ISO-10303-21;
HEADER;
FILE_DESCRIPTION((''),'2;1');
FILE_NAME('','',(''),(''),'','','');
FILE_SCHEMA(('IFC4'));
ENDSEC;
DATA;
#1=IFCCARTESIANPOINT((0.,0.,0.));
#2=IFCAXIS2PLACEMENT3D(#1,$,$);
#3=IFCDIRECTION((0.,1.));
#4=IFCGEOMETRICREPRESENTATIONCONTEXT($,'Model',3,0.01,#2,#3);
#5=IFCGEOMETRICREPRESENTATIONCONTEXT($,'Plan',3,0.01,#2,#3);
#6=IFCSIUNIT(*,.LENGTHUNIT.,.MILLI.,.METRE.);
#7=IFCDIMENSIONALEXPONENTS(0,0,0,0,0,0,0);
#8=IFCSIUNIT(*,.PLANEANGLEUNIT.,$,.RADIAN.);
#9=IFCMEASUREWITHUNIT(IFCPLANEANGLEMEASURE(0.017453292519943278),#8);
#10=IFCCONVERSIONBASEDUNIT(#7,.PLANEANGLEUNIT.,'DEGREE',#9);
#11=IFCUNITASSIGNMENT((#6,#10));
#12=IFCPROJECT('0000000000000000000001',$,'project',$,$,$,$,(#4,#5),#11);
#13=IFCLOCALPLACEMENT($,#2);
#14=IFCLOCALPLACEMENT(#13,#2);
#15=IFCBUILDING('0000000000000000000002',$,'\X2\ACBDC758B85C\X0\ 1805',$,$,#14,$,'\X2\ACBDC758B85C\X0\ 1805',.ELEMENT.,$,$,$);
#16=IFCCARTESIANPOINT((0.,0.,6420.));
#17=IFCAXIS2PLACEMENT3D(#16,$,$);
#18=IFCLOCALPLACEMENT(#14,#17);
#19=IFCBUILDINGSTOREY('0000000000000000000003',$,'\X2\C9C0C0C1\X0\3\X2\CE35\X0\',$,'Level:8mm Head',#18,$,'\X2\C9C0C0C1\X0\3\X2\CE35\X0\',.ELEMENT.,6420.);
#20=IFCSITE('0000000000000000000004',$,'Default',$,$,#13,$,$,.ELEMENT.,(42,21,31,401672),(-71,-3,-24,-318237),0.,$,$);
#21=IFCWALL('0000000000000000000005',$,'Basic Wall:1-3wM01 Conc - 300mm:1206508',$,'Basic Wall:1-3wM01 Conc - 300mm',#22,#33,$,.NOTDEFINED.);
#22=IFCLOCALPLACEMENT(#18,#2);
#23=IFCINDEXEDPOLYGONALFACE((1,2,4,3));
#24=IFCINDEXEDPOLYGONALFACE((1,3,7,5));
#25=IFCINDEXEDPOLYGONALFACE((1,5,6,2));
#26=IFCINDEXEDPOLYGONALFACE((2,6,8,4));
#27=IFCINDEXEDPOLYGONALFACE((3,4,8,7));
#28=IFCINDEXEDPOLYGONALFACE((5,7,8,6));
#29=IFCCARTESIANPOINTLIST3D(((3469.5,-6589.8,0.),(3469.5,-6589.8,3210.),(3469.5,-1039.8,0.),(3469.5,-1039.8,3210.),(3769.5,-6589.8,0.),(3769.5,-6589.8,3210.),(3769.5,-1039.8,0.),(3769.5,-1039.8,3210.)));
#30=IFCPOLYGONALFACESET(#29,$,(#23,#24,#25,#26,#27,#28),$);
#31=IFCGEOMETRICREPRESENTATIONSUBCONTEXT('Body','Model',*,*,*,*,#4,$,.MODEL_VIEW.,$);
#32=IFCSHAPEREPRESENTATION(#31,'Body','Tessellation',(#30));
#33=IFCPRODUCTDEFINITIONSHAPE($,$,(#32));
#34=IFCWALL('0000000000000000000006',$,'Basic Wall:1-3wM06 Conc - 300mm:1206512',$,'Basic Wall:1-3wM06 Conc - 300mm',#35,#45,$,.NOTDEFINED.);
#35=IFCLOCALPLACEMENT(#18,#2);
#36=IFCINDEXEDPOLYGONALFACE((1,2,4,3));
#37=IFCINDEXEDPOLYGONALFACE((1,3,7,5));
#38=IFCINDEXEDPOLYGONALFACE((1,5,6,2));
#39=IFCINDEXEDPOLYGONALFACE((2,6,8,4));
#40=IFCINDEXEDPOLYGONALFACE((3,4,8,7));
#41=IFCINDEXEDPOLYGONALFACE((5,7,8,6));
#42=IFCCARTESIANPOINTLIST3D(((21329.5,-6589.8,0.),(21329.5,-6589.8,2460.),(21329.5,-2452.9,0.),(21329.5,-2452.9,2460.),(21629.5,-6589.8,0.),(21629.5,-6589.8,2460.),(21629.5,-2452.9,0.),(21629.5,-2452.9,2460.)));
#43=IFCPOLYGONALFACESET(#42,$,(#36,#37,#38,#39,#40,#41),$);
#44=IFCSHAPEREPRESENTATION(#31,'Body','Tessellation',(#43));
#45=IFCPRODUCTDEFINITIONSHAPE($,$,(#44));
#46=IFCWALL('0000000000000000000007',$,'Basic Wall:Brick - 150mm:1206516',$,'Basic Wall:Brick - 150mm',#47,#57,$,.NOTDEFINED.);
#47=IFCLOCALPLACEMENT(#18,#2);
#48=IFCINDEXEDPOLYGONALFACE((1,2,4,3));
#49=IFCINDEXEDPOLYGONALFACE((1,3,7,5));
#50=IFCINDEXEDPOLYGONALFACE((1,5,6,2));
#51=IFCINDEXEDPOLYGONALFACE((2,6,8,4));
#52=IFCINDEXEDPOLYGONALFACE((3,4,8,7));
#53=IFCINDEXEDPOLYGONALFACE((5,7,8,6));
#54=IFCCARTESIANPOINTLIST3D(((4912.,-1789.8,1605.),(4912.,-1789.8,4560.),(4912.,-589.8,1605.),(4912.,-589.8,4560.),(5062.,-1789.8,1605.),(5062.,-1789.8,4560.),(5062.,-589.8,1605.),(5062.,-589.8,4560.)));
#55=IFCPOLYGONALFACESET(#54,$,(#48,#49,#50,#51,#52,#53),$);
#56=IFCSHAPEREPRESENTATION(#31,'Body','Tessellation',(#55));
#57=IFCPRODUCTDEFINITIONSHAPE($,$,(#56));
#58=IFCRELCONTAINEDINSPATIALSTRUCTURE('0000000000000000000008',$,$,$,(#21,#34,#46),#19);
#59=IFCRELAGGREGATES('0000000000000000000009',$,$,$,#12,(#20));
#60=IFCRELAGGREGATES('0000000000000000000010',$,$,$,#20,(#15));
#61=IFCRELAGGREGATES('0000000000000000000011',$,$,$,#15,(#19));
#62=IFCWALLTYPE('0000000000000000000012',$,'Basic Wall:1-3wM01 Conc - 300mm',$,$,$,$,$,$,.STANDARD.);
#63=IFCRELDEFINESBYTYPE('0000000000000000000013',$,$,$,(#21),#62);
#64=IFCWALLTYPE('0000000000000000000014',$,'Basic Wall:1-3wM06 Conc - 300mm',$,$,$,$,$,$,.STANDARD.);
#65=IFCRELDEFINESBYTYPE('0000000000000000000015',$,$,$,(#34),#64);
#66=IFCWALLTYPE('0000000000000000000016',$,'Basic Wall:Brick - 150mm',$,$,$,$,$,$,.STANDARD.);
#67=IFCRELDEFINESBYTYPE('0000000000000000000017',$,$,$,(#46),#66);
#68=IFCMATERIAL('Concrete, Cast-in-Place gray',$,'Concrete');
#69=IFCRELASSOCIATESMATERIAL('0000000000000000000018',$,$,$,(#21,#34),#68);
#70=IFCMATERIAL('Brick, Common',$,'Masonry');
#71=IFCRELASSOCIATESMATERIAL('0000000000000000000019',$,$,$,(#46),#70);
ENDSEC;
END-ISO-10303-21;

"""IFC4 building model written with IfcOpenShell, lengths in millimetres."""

from ifc_helpers import new_model, entity, si_unit, converted_unit, direction, frame, origin, place, context, subcontext, project, spatial, indexed_curve, outline, extrude, material, type_object, element, save


model = new_model("IFC4")

# Units and contexts
model_context = context("Model", 3, precision=0.01, world=origin(), true_north=direction((0.0, 1.0)))
plan_context = context("Plan", 3, precision=0.01, world=origin(), true_north=direction((0.0, 1.0)))
body_context = subcontext(model_context, "Body", "Model", "MODEL_VIEW")
ifc_project = project(units=[si_unit("LENGTHUNIT", "METRE", prefix="MILLI"), converted_unit("PLANEANGLEUNIT", "DEGREE", entity("IfcPlaneAngleMeasure", 0.017453292519943278), si_unit("PLANEANGLEUNIT", "RADIAN"), dimensions=[0, 0, 0, 0, 0, 0, 0])], contexts=[model_context, plan_context])

# Site, building, storey
site_placement = place(None, origin())
site = spatial("IfcSite", under=ifc_project, at=site_placement, Name="Default", CompositionType="ELEMENT", RefLatitude=(42, 21, 31, 401672), RefLongitude=(-71, -3, -24, -318237), RefElevation=0.0)
building_placement = place(site_placement, origin())
building = spatial("IfcBuilding", under=site, at=building_placement, Name="경의로 1805", LongName="경의로 1805", CompositionType="ELEMENT")
storey_placement = place(building_placement, frame((0.0, 0.0, 6420.0)))
storey = spatial("IfcBuildingStorey", under=building, at=storey_placement, Name="지상3층", ObjectType="Level:8mm Head", LongName="지상3층", CompositionType="ELEMENT", Elevation=6420.0)

# Walls
ifc_material_1 = material(Name="Concrete, Cast-in-Place gray", Category="Concrete")
wall_type_1 = type_object("IfcWallType", Name="Basic Wall:1-3wM01 Conc - 300mm", PredefinedType="STANDARD")
wall_1_placement = place(storey_placement, frame((3619.5, -6589.8, 0.0), z_axis=(0.0, 0.0, 1.0), x_axis=(0.0, 1.0, 0.0)))
element("IfcWall", 1, at=wall_1_placement, inside=storey, type_object=wall_type_1, material=ifc_material_1, Name="Basic Wall:1-3wM01 Conc - 300mm:1206508", ObjectType="Basic Wall:1-3wM01 Conc - 300mm", PredefinedType="NOTDEFINED", context=body_context, shape_type="SweptSolid", body=[
    extrude(outline(indexed_curve([(5550.0, 150.0), (0.0, 150.0), (0.0, -150.0), (5550.0, -150.0), (5550.0, 150.0)], self_intersect=False)), origin(), (0.0, 0.0, 1.0), 3210.0),
])
wall_type_2 = type_object("IfcWallType", Name="Basic Wall:1-3wM06 Conc - 300mm", PredefinedType="STANDARD")
wall_2_placement = place(storey_placement, frame((21479.5, -2452.9, 0.0), z_axis=(0.0, 0.0, 1.0), x_axis=(0.0, -1.0, 0.0)))
element("IfcWall", 2, at=wall_2_placement, inside=storey, type_object=wall_type_2, material=ifc_material_1, Name="Basic Wall:1-3wM06 Conc - 300mm:1206512", ObjectType="Basic Wall:1-3wM06 Conc - 300mm", PredefinedType="NOTDEFINED", context=body_context, shape_type="SweptSolid", body=[
    extrude(outline(indexed_curve([(4136.9, 150.0), (0.0, 150.0), (0.0, -150.0), (4136.9, -150.0), (4136.9, 150.0)], self_intersect=False)), origin(), (0.0, 0.0, 1.0), 2460.0),
])
ifc_material_2 = material(Name="Brick, Common", Category="Masonry")
wall_type_3 = type_object("IfcWallType", Name="Basic Wall:Brick - 150mm", PredefinedType="STANDARD")
wall_3_placement = place(storey_placement, frame((4987.0, -1789.8, 1605.0), z_axis=(0.0, 0.0, 1.0), x_axis=(0.0, 1.0, 0.0)))
element("IfcWall", 3, at=wall_3_placement, inside=storey, type_object=wall_type_3, material=ifc_material_2, Name="Basic Wall:Brick - 150mm:1206516", ObjectType="Basic Wall:Brick - 150mm", PredefinedType="NOTDEFINED", context=body_context, shape_type="SweptSolid", body=[
    extrude(outline(indexed_curve([(1200.0, 75.0), (0.0, 75.0), (0.0, -75.0), (1200.0, -75.0), (1200.0, 75.0)], self_intersect=False)), origin(), (0.0, 0.0, 1.0), 2955.0),
])

save(model, "model.ifc")
